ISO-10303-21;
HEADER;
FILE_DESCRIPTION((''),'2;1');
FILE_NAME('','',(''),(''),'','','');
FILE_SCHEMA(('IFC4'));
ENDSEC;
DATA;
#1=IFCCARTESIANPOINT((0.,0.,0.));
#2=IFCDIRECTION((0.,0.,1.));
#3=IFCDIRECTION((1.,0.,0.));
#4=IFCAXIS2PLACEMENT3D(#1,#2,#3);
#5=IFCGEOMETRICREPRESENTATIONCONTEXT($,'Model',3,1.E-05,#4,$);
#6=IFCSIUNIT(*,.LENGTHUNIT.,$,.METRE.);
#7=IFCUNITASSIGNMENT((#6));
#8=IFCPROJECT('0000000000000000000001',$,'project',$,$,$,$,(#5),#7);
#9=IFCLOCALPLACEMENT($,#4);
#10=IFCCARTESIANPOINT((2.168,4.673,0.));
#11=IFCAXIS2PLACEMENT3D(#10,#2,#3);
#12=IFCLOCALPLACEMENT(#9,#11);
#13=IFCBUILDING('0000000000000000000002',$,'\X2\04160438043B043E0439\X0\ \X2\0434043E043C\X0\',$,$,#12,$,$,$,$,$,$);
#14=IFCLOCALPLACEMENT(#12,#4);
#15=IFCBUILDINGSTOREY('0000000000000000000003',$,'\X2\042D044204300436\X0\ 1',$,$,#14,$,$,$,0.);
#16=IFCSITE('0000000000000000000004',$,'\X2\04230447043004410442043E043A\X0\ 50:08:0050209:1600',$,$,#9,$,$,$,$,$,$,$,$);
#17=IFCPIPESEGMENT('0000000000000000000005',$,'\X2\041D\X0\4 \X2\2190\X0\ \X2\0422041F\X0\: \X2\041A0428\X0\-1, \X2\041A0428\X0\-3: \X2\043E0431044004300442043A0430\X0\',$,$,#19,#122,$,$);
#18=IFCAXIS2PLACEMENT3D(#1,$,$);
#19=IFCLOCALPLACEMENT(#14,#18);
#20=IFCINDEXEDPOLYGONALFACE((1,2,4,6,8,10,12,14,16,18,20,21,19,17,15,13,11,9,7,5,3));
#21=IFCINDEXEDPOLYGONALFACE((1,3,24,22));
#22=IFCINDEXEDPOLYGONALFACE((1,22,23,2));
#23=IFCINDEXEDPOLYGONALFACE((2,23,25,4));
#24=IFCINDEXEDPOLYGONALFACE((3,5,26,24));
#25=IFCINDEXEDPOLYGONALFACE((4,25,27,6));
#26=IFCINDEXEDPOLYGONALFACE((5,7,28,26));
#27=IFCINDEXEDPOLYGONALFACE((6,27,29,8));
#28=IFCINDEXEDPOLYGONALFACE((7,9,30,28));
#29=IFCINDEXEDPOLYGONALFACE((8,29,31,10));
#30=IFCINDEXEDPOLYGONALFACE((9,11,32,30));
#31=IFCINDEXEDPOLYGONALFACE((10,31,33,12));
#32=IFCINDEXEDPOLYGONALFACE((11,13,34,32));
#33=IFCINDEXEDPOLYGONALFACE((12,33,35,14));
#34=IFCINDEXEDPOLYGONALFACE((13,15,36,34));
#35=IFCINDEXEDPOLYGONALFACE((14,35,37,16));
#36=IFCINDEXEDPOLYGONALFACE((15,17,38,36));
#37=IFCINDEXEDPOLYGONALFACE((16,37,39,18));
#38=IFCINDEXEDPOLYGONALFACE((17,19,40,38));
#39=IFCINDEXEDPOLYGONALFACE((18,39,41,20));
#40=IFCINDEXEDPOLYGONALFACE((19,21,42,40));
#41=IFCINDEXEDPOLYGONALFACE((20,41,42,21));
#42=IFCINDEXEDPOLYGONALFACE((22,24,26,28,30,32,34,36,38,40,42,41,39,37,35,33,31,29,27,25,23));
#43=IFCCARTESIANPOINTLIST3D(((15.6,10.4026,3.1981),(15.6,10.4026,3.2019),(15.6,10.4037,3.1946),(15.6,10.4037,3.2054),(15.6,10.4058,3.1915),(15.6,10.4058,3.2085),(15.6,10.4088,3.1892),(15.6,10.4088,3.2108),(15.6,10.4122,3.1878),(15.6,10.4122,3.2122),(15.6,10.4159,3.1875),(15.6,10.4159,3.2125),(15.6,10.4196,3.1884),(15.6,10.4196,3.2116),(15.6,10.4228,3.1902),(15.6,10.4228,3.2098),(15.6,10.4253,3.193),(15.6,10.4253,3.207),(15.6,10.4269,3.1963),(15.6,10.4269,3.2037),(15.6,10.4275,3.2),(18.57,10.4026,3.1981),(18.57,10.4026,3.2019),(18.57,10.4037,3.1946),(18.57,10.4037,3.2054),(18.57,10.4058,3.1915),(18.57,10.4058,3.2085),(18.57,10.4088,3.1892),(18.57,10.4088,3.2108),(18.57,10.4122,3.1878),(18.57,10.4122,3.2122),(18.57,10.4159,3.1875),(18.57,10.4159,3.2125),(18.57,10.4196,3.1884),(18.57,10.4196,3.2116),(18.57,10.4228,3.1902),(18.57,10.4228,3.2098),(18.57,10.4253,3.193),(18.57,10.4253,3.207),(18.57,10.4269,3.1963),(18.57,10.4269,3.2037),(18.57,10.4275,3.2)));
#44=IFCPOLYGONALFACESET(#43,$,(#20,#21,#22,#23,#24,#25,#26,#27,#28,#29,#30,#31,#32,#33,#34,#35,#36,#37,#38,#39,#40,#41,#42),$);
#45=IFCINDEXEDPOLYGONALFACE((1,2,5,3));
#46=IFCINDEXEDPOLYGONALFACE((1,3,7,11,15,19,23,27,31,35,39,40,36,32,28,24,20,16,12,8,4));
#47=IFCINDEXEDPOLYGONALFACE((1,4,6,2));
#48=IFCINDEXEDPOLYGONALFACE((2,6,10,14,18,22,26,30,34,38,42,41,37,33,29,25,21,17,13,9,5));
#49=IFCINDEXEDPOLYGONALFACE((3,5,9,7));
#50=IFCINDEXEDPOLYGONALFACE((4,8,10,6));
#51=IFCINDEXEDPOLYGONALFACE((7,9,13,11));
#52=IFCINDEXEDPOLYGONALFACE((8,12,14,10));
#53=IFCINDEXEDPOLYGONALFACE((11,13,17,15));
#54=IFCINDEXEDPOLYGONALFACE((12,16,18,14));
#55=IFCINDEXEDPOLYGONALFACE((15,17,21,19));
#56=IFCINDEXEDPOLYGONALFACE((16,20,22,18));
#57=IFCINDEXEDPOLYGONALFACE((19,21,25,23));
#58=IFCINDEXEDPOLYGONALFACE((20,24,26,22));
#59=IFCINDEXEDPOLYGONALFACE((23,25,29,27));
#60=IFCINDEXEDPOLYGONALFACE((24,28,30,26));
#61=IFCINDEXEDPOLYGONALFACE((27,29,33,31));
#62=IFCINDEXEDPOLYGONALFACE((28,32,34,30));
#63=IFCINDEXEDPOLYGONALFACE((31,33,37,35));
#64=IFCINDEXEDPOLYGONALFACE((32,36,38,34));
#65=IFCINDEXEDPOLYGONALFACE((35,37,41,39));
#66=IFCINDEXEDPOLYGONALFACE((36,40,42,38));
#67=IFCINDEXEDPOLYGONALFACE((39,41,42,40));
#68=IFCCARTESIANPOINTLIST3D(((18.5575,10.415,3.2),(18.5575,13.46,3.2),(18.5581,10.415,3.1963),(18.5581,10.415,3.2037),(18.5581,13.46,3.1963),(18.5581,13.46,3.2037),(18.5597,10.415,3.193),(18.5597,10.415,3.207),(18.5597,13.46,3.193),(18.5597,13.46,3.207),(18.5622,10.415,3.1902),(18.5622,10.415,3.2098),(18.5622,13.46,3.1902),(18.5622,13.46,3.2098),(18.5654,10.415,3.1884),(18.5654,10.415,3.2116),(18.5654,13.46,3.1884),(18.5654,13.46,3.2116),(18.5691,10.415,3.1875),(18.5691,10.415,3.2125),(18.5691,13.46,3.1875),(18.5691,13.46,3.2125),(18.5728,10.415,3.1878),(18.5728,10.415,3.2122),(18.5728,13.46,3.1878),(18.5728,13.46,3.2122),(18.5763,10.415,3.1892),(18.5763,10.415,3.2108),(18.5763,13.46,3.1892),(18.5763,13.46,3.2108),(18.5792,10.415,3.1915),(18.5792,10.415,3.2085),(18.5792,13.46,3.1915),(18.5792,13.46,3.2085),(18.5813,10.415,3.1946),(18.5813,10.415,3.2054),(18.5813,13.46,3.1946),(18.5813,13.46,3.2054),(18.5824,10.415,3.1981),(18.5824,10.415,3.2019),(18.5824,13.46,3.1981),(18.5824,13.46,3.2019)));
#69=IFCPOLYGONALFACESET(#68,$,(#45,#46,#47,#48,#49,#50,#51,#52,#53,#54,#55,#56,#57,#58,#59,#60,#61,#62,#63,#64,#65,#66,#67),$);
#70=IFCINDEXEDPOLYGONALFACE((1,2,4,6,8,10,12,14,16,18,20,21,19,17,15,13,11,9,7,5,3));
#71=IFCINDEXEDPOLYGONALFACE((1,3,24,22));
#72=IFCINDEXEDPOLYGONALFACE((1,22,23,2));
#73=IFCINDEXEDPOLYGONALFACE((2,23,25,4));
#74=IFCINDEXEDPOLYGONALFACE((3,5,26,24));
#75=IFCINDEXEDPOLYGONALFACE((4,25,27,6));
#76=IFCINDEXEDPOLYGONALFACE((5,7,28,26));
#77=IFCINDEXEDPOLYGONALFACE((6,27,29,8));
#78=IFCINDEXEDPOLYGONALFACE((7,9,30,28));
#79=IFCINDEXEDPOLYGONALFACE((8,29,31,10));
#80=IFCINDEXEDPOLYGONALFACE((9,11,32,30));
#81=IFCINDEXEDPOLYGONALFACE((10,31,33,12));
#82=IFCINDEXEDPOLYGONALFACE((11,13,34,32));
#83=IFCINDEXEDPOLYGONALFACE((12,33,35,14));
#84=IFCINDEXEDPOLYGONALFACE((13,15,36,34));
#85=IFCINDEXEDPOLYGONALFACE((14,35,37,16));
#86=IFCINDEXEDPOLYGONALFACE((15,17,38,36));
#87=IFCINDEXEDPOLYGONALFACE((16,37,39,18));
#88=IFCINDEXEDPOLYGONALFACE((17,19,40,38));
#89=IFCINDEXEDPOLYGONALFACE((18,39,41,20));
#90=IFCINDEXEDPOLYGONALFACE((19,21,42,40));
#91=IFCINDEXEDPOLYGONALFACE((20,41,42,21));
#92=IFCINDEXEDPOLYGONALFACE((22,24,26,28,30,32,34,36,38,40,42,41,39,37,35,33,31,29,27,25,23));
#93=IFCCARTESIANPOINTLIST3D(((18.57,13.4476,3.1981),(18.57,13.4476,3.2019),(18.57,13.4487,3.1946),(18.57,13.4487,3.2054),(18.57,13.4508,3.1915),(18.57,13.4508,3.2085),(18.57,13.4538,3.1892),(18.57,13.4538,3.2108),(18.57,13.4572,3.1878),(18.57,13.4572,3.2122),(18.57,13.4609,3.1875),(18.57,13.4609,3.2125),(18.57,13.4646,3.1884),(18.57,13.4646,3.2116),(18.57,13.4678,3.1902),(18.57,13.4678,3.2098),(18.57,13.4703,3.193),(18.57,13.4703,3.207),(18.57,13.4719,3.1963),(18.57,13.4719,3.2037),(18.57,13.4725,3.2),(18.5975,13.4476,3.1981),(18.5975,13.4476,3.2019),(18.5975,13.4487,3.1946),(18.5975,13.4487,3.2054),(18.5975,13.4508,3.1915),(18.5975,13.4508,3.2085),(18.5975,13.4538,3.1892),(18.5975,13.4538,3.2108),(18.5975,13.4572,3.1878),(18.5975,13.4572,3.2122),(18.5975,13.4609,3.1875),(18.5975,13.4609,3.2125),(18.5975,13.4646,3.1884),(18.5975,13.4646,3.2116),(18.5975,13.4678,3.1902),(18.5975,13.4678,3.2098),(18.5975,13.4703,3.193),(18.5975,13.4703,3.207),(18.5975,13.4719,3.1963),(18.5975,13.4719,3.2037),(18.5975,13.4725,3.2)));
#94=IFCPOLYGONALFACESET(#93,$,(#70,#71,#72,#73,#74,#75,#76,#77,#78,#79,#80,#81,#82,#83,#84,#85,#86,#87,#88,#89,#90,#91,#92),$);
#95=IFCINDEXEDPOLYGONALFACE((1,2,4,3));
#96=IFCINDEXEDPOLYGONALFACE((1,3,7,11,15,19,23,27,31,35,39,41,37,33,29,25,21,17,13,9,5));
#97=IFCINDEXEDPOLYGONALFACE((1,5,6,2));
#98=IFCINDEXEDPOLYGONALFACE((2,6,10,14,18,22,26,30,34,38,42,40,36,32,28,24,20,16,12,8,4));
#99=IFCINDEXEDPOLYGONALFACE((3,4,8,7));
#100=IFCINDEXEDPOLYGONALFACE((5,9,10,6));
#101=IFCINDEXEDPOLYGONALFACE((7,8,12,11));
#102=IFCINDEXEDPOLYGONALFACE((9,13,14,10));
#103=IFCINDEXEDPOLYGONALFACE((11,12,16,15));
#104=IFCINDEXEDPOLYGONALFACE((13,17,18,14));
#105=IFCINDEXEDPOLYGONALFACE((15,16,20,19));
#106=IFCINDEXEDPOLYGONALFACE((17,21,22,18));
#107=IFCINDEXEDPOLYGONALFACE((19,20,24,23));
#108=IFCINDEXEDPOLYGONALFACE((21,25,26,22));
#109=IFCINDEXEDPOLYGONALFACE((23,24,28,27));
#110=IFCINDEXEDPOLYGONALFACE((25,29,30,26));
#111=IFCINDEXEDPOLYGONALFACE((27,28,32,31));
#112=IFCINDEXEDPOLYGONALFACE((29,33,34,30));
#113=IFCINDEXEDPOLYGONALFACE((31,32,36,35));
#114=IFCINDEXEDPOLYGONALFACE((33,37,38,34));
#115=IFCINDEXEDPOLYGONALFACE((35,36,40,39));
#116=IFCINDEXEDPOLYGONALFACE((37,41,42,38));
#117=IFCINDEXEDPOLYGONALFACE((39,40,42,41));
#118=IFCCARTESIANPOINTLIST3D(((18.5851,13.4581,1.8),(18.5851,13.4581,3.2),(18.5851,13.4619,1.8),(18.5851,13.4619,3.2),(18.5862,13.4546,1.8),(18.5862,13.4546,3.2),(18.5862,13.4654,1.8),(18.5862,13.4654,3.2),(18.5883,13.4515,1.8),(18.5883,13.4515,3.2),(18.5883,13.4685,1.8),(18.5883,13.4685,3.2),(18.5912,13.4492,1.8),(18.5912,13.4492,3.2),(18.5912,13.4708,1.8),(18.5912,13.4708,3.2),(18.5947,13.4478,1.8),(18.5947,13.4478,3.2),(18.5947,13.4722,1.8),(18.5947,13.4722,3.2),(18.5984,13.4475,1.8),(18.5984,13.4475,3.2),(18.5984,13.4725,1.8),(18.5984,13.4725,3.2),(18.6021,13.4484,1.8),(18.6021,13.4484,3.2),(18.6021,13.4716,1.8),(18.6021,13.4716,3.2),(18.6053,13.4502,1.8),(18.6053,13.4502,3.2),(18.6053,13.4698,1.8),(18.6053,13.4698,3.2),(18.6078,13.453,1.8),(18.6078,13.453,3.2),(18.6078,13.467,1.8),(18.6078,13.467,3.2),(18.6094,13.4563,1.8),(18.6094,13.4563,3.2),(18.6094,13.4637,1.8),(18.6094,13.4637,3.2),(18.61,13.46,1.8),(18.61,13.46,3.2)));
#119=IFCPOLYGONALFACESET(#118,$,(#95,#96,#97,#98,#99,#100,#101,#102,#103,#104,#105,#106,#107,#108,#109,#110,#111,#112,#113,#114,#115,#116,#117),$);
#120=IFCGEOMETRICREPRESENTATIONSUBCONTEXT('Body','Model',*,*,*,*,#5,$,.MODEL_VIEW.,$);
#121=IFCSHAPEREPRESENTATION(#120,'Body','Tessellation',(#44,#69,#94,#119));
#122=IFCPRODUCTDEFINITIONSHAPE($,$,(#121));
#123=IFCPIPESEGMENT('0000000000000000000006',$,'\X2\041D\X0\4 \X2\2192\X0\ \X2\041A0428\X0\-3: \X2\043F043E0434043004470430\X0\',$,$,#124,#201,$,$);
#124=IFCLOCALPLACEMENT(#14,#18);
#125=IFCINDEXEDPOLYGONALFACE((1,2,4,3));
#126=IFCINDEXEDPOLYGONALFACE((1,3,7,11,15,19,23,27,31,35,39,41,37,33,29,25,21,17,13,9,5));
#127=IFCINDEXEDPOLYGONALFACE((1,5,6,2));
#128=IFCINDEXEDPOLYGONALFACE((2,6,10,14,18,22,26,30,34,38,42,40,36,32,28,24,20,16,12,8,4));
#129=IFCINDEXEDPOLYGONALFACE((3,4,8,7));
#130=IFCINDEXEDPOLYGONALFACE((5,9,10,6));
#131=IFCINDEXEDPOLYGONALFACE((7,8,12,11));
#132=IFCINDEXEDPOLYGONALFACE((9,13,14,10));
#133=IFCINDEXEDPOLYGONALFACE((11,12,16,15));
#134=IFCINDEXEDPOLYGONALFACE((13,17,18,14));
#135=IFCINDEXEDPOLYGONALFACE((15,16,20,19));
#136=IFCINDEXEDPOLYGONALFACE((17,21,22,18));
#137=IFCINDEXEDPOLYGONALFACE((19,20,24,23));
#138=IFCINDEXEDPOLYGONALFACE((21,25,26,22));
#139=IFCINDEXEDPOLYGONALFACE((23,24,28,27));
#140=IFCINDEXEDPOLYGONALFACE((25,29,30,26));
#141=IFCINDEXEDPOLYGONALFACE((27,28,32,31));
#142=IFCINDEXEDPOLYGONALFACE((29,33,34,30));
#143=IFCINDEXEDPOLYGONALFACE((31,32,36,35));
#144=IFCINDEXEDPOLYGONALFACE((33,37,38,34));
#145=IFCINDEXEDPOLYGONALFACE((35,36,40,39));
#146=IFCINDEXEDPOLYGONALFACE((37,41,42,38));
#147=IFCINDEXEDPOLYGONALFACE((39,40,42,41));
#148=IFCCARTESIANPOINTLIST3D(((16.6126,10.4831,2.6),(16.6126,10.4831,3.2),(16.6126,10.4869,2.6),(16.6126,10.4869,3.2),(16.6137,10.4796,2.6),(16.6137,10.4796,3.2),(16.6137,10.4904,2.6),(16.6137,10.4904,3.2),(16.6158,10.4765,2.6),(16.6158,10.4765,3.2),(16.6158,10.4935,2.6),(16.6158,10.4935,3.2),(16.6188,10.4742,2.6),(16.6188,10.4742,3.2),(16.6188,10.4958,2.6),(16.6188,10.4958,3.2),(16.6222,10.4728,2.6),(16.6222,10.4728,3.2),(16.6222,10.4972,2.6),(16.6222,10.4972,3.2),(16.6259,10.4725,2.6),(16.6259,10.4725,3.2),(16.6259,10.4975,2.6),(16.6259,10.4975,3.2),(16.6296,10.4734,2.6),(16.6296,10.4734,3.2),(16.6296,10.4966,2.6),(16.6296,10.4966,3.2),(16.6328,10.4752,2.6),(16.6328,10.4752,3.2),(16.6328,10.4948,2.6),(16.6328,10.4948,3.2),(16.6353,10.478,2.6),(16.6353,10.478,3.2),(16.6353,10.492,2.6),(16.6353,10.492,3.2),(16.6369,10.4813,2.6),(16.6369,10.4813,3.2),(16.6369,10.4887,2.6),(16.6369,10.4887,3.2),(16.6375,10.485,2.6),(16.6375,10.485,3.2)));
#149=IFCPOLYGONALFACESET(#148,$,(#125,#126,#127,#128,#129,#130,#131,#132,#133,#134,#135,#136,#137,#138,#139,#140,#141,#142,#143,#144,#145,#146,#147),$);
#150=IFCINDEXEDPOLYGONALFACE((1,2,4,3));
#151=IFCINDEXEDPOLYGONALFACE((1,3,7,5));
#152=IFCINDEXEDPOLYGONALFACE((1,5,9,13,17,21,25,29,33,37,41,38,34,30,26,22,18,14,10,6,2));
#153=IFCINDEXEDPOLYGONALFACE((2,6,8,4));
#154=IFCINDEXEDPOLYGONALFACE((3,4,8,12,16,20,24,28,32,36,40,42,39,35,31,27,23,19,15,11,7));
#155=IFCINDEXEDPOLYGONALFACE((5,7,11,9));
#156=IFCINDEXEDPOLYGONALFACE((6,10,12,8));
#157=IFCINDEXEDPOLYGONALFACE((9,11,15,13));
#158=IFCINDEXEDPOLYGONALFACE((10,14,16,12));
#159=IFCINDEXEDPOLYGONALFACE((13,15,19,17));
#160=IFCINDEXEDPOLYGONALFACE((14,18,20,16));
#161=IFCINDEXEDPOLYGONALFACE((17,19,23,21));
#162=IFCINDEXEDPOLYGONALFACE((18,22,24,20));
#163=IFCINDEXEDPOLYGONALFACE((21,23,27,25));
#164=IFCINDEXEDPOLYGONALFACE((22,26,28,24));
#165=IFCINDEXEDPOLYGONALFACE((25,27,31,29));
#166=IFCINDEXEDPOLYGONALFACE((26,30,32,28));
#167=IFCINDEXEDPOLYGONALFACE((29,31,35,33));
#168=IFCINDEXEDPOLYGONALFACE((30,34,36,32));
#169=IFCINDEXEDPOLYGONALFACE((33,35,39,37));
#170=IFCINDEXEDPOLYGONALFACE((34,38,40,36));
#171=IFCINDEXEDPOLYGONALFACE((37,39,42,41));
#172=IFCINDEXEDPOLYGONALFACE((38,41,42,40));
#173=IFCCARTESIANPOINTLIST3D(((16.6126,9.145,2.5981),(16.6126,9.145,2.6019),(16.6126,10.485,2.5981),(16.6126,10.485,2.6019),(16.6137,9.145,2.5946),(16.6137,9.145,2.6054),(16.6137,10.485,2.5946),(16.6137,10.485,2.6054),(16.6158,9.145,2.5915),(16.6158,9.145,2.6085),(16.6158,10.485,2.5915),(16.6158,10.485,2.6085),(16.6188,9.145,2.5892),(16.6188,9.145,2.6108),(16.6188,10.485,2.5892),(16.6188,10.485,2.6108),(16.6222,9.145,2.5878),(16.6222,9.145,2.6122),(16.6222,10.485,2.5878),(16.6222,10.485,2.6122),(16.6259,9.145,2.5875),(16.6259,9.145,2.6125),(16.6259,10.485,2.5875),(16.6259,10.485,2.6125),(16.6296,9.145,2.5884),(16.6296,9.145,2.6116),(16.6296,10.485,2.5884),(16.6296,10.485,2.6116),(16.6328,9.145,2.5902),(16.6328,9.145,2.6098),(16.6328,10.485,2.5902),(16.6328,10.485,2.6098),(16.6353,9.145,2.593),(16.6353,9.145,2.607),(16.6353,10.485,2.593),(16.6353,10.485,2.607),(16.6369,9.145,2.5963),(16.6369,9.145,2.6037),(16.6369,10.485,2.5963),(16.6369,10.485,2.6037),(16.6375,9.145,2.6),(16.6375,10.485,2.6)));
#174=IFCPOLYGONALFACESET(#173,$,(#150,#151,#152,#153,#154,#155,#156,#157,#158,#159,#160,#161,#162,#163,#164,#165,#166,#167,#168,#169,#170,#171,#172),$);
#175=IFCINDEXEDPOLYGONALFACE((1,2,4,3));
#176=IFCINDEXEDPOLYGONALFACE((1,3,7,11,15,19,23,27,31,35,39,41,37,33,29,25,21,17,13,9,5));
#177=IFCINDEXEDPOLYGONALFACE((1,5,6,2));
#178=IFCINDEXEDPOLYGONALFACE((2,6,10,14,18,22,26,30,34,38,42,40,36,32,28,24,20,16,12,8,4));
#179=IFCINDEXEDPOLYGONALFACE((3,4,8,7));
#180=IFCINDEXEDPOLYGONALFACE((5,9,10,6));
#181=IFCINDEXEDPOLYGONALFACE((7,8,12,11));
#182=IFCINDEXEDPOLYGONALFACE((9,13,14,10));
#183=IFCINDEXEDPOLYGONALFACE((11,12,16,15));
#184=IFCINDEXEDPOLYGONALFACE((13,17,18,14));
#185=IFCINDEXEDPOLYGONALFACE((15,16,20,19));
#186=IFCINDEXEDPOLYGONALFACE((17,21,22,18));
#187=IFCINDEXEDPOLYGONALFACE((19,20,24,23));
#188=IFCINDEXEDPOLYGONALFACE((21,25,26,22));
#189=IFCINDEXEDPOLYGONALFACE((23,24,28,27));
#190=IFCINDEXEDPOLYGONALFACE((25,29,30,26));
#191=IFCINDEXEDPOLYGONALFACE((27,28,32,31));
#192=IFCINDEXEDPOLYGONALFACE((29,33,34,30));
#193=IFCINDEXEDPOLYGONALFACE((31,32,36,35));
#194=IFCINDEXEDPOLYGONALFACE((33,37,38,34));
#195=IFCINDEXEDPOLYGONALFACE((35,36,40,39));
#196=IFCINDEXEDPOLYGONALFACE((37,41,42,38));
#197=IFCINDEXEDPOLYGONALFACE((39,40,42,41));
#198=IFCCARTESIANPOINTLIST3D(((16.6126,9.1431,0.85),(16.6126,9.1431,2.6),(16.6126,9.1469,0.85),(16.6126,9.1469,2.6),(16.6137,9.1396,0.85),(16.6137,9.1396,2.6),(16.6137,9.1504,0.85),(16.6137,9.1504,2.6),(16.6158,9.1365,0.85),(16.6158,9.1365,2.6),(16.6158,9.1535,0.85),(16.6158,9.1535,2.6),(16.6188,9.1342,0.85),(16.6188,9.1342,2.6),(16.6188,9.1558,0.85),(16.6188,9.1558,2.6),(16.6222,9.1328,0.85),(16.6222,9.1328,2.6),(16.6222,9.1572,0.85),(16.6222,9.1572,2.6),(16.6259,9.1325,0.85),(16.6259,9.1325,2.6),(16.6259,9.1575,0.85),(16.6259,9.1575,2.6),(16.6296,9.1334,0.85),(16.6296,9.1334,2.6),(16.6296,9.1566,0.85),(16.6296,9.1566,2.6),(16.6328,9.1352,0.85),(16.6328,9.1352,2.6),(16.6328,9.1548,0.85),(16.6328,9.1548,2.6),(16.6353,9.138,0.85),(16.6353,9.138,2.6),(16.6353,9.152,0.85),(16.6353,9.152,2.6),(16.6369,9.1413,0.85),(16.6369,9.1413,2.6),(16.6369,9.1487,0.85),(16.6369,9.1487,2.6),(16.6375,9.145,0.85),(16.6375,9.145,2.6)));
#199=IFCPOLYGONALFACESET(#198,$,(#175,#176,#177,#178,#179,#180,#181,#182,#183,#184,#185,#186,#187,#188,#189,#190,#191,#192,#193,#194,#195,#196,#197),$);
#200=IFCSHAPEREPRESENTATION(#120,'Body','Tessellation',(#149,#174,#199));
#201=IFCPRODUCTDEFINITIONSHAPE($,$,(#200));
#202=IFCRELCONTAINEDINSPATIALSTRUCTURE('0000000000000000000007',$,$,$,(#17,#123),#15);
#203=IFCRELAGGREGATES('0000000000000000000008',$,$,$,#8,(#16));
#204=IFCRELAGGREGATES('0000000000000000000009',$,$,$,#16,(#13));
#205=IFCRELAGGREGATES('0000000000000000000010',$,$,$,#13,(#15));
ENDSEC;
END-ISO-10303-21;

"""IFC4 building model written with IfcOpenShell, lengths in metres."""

from ifc_helpers import new_model, si_unit, frame, origin_with_axes, origin_2d, place, context, subcontext, project, spatial, circle, extrude, element, save


model = new_model("IFC4")

# Units and contexts
model_context = context("Model", 3, precision=1e-05, world=origin_with_axes())
body_context = subcontext(model_context, "Body", "Model", "MODEL_VIEW")
ifc_project = project(units=[si_unit("LENGTHUNIT", "METRE")], contexts=[model_context])

# Site, building, storey
site_placement = place(None, origin_with_axes())
site = spatial("IfcSite", under=ifc_project, at=site_placement, Name="Участок 50:08:0050209:1600")
building_placement = place(site_placement, frame((2.168, 4.673, 0.0), z_axis=(0.0, 0.0, 1.0), x_axis=(1.0, 0.0, 0.0)))
building = spatial("IfcBuilding", under=site, at=building_placement, Name="Жилой дом")
storey_placement = place(building_placement, origin_with_axes())
storey = spatial("IfcBuildingStorey", under=building, at=storey_placement, Name="Этаж 1", Elevation=0.0)

# Pipe segments
pipe_segment_1_placement = place(storey_placement, origin_with_axes())
element("IfcPipeSegment", 1, at=pipe_segment_1_placement, inside=storey, Name="Н4 ← ТП: КШ-1, КШ-3: обратка", context=body_context, shape_type="SweptSolid", body=[
    extrude(circle(Radius=0.0125, at=origin_2d()), frame((15.6, 10.415, 3.2), z_axis=(1.0, 0.0, 0.0), x_axis=(0.0, 1.0, 0.0)), (0.0, 0.0, 1.0), 2.97),
    extrude(circle(Radius=0.0125, at=origin_2d()), frame((18.57, 10.415, 3.2), z_axis=(0.0, 1.0, 0.0), x_axis=(-1.0, 0.0, 0.0)), (0.0, 0.0, 1.0), 3.045),
    extrude(circle(Radius=0.0125, at=origin_2d()), frame((18.57, 13.46, 3.2), z_axis=(1.0, 0.0, 0.0), x_axis=(0.0, 1.0, 0.0)), (0.0, 0.0, 1.0), 0.0275),
    extrude(circle(Radius=0.0125, at=origin_2d()), frame((18.5975, 13.46, 3.2), z_axis=(0.0, 0.0, -1.0), x_axis=(1.0, 0.0, 0.0)), (0.0, 0.0, 1.0), 1.4),
])
pipe_segment_2_placement = place(storey_placement, origin_with_axes())
element("IfcPipeSegment", 2, at=pipe_segment_2_placement, inside=storey, Name="Н4 → КШ-3: подача", context=body_context, shape_type="SweptSolid", body=[
    extrude(circle(Radius=0.0125, at=origin_2d()), frame((16.625, 10.485, 3.2), z_axis=(0.0, 0.0, -1.0), x_axis=(1.0, 0.0, 0.0)), (0.0, 0.0, 1.0), 0.6),
    extrude(circle(Radius=0.0125, at=origin_2d()), frame((16.625, 10.485, 2.6), z_axis=(0.0, -1.0, 0.0), x_axis=(1.0, 0.0, 0.0)), (0.0, 0.0, 1.0), 1.34),
    extrude(circle(Radius=0.0125, at=origin_2d()), frame((16.625, 9.145, 2.6), z_axis=(0.0, 0.0, -1.0), x_axis=(1.0, 0.0, 0.0)), (0.0, 0.0, 1.0), 1.75),
])

save(model, "model.ifc")
